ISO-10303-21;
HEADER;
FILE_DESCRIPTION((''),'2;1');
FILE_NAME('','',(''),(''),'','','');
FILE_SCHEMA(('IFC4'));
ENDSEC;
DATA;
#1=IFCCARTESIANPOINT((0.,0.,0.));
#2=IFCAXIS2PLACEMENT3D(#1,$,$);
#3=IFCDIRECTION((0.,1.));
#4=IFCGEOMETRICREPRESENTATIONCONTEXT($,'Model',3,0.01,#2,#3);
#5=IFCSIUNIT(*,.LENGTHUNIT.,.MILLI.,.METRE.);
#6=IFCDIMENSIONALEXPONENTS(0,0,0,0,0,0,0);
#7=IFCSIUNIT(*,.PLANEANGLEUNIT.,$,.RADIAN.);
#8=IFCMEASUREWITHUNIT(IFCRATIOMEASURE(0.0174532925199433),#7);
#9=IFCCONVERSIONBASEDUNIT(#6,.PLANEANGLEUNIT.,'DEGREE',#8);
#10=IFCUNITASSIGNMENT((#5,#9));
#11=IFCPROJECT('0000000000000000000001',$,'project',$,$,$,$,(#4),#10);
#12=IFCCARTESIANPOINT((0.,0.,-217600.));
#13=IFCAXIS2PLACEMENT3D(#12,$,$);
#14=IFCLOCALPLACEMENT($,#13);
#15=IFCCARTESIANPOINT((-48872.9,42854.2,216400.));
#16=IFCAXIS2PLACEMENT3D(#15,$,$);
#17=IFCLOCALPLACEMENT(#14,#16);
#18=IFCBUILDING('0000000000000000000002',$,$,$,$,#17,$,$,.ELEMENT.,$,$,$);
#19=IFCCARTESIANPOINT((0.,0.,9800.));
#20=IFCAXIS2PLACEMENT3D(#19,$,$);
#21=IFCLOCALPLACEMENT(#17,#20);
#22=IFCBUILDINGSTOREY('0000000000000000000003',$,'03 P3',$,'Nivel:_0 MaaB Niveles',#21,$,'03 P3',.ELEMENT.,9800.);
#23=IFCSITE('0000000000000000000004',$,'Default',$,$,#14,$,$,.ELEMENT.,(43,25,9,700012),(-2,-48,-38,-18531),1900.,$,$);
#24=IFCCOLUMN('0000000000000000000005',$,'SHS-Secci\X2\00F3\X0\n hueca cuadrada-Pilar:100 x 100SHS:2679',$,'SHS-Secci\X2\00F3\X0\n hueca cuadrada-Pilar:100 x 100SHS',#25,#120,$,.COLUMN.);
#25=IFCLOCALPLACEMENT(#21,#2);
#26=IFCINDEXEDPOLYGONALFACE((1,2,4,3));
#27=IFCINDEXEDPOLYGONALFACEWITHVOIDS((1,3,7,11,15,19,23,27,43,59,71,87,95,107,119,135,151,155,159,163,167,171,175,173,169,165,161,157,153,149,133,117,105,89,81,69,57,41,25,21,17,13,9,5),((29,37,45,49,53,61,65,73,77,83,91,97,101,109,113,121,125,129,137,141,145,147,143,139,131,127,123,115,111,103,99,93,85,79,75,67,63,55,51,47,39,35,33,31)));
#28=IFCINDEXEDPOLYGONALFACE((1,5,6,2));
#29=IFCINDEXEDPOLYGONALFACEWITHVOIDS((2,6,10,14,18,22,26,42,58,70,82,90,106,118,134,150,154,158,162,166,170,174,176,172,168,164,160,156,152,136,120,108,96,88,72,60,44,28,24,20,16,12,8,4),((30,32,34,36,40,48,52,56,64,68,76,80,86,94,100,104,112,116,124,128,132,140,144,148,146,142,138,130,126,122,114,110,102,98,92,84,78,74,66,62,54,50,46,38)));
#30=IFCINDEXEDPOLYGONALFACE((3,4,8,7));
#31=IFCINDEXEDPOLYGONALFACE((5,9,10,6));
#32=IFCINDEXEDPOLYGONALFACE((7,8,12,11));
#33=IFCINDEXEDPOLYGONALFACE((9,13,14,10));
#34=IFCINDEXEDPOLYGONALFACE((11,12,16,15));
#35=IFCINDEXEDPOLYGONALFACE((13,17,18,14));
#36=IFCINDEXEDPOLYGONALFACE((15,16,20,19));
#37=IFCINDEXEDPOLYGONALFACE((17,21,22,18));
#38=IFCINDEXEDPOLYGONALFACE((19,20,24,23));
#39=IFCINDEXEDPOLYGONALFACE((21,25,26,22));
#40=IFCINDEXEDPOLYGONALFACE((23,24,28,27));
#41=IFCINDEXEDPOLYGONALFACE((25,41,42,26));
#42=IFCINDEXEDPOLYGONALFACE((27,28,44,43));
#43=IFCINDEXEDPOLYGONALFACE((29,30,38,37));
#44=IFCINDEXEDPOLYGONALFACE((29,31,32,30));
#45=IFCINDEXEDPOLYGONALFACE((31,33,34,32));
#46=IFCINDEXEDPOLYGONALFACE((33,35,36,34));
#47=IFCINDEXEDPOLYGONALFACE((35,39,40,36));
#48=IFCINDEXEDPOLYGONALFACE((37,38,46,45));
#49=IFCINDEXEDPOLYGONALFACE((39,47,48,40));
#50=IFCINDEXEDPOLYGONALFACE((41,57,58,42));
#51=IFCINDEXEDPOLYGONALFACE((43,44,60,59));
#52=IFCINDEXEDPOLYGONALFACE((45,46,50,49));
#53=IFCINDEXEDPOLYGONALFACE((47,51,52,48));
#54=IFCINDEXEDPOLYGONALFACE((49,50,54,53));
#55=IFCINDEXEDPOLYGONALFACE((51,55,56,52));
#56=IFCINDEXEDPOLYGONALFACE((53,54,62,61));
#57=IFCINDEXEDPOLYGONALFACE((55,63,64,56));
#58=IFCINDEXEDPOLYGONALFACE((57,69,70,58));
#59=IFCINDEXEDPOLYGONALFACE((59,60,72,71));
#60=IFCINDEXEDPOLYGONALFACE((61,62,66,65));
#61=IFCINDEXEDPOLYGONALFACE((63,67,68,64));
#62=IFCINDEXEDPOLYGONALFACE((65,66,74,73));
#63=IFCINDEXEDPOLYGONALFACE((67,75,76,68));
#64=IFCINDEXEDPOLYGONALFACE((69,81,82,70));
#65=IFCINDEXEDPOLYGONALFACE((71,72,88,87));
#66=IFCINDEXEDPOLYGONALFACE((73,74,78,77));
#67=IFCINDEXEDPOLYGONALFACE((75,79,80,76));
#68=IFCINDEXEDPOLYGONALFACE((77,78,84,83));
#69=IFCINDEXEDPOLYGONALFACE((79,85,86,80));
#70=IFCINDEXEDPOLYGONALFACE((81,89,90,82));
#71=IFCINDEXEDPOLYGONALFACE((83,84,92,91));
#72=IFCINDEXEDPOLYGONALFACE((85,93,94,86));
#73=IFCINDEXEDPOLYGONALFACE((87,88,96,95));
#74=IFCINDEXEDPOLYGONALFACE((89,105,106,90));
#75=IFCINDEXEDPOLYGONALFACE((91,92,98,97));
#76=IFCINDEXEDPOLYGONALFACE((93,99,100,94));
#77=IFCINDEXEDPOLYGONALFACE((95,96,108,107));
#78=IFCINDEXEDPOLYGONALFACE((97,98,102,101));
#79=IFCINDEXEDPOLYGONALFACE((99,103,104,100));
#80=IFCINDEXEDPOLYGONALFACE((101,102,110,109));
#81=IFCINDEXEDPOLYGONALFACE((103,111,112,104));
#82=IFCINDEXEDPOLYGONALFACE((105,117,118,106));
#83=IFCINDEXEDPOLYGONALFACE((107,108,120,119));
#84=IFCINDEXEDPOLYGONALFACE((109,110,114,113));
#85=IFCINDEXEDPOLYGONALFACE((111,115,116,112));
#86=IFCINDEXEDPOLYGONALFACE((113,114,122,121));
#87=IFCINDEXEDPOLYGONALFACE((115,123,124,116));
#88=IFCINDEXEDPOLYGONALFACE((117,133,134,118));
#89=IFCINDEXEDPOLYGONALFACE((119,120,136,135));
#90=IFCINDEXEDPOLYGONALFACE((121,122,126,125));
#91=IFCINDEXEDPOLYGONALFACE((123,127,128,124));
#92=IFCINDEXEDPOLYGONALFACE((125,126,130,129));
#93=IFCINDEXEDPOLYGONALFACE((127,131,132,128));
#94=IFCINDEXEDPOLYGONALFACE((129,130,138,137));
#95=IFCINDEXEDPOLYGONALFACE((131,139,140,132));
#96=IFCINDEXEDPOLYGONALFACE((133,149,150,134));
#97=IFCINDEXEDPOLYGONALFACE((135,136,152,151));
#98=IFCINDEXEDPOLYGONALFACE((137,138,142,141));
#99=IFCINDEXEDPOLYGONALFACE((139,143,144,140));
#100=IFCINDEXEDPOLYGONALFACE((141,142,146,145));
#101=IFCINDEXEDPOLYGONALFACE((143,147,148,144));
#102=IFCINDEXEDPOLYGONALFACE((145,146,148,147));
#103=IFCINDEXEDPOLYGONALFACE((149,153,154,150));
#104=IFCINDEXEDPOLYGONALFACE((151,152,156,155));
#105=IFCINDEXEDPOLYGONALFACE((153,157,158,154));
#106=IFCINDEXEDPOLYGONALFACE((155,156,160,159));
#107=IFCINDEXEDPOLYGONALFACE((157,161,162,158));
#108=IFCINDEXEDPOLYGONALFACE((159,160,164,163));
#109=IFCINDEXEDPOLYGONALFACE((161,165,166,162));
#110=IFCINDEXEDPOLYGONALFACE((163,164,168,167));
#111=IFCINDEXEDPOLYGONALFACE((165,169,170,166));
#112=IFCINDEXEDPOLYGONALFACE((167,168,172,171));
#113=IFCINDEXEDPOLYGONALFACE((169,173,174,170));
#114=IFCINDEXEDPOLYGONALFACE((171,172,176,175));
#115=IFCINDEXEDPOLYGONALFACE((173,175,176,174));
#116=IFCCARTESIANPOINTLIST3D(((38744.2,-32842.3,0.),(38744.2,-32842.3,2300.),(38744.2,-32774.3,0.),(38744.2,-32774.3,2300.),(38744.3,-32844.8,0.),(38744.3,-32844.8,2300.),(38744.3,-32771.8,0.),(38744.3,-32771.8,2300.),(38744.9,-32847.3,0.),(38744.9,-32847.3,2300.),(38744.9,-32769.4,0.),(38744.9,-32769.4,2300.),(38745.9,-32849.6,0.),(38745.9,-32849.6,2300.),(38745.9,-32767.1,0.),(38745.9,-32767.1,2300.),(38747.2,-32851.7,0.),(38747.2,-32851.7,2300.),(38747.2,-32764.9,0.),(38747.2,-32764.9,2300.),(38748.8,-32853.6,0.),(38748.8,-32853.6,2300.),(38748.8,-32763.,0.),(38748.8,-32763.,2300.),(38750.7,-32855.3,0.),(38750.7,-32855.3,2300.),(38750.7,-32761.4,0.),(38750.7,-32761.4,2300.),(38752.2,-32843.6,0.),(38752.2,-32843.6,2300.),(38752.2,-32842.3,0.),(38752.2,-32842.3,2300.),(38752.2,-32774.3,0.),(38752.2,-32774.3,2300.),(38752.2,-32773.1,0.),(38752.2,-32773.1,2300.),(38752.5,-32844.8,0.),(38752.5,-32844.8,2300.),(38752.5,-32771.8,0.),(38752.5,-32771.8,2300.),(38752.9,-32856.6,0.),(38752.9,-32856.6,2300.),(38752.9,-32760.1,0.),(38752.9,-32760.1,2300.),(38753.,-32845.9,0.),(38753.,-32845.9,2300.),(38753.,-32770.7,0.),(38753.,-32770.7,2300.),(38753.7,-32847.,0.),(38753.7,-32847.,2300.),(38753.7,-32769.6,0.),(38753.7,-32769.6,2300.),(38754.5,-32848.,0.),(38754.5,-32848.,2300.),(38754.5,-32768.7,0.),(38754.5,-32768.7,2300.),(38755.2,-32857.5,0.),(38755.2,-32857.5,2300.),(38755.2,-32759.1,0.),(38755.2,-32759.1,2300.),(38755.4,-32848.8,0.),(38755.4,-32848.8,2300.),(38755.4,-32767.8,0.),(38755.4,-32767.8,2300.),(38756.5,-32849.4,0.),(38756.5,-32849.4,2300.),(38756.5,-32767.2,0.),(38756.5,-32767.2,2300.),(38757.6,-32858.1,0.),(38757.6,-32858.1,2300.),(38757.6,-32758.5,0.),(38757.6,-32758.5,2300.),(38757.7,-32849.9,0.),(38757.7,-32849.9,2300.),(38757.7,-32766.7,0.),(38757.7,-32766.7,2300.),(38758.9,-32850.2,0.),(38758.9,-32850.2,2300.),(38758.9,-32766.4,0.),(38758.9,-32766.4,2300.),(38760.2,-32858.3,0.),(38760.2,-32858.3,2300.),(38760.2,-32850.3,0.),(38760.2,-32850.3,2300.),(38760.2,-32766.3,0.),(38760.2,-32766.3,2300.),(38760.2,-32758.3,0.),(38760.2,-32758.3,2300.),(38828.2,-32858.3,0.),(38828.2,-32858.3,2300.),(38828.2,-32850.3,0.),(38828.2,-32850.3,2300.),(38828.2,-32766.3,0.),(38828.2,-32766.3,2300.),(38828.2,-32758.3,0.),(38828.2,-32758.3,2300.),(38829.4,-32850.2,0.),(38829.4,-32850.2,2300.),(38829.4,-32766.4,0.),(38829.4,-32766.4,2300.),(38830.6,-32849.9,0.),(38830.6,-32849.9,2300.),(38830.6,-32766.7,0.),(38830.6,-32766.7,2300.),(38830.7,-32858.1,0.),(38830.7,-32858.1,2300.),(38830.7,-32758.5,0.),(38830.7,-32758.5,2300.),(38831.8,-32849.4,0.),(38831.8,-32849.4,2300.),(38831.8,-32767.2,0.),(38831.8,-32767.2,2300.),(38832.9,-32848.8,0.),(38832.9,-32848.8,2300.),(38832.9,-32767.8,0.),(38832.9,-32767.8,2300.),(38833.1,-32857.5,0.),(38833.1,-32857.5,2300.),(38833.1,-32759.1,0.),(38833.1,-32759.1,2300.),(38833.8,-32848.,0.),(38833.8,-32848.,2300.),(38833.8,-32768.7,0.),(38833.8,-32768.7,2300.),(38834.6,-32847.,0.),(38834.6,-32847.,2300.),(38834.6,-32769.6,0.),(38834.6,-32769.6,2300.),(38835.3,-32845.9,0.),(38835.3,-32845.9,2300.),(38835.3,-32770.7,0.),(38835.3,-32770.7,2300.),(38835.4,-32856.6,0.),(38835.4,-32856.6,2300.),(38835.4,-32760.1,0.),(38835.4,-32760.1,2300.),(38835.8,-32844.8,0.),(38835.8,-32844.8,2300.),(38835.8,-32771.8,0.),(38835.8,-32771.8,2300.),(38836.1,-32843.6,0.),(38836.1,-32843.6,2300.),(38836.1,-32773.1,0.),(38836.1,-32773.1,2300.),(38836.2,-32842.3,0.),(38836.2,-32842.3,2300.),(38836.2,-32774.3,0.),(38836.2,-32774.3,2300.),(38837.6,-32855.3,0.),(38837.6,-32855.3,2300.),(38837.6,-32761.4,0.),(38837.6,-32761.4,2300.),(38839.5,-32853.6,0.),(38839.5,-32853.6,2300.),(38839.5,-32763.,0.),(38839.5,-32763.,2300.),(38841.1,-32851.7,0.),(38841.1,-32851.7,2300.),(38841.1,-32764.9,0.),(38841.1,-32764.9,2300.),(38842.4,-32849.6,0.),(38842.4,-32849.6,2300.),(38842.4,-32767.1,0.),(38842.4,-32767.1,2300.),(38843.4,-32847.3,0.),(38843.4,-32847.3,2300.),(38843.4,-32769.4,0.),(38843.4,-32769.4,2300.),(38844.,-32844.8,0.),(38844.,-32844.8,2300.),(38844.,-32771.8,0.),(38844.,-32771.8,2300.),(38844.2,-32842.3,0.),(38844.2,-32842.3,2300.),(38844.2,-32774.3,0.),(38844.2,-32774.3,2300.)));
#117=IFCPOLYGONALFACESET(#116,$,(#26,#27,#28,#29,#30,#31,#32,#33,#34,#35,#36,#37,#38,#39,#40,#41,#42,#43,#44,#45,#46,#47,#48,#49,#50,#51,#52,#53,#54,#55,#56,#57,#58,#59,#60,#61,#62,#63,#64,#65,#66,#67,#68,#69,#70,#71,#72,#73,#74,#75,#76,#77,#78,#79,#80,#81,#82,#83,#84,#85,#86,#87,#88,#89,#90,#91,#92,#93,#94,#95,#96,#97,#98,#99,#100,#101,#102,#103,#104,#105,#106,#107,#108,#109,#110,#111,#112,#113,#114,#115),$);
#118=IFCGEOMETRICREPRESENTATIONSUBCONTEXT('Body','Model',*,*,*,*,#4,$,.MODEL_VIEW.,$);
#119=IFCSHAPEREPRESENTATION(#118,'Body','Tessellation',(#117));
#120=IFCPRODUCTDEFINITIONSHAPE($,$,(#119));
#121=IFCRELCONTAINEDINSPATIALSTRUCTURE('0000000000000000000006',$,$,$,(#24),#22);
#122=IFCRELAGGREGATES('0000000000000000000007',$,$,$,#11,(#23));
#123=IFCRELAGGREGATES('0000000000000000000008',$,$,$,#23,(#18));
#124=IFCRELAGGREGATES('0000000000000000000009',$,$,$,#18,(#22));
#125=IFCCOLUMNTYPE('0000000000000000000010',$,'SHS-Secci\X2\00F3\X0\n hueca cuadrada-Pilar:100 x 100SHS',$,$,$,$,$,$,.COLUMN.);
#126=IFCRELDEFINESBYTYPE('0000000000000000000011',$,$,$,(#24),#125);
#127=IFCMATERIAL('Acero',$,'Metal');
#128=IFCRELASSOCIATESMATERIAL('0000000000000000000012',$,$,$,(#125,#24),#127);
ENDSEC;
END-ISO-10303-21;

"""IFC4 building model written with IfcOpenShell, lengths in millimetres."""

from ifc_helpers import new_model, entity, si_unit, converted_unit, direction, frame, origin, place, context, subcontext, project, spatial, indexed_curve, outline, extrude, source, transform, mapped, material, type_object, type_shapes, element, save


model = new_model("IFC4")

# Units and contexts
model_context = context("Model", 3, precision=0.01, world=origin(), true_north=direction((0.0, 1.0)))
body_context = subcontext(model_context, "Body", "Model", "MODEL_VIEW")
ifc_project = project(units=[si_unit("LENGTHUNIT", "METRE", prefix="MILLI"), converted_unit("PLANEANGLEUNIT", "DEGREE", entity("IfcRatioMeasure", 0.0174532925199433), si_unit("PLANEANGLEUNIT", "RADIAN"), dimensions=[0, 0, 0, 0, 0, 0, 0])], contexts=[model_context])

# Site, building, storey
site_placement = place(None, frame((0.0, 0.0, -217600.0)))
site = spatial("IfcSite", under=ifc_project, at=site_placement, Name="Default", CompositionType="ELEMENT", RefLatitude=(43, 25, 9, 700012), RefLongitude=(-2, -48, -38, -18531), RefElevation=1900.0)
building_placement = place(site_placement, frame((-48872.9, 42854.2, 216400.0)))
building = spatial("IfcBuilding", under=site, at=building_placement, CompositionType="ELEMENT")
storey_placement = place(building_placement, frame((0.0, 0.0, 9800.0)))
storey = spatial("IfcBuildingStorey", under=building, at=storey_placement, Name="03 P3", ObjectType="Nivel:_0 MaaB Niveles", LongName="03 P3", CompositionType="ELEMENT", Elevation=9800.0)

# Column
ifc_material_1 = material(Name="Acero", Category="Metal")
column_type_1 = type_object("IfcColumnType", Name="SHS-Sección hueca cuadrada-Pilar:100 x 100SHS", PredefinedType="COLUMN", material=ifc_material_1)
shared_shape_1 = source(origin(), body_context, "Body", "SweptSolid", [
    extrude(outline(indexed_curve([(-34.0, -50.0), (34.0, -50.0), (36.5, -49.8), (38.9, -49.2), (41.3, -48.3), (43.4, -46.9), (45.3, -45.3), (46.9, -43.4), (48.3, -41.3), (49.2, -38.9), (49.8, -36.5), (50.0, -34.0), (50.0, 34.0), (49.8, 36.5), (49.2, 38.9), (48.3, 41.3), (46.9, 43.4), (45.3, 45.3), (43.4, 46.9), (41.3, 48.3), (38.9, 49.2), (36.5, 49.8), (34.0, 50.0), (-34.0, 50.0), (-36.5, 49.8), (-38.9, 49.2), (-41.3, 48.3), (-43.4, 46.9), (-45.3, 45.3), (-46.9, 43.4), (-48.3, 41.3), (-49.2, 38.9), (-49.8, 36.5), (-50.0, 34.0), (-50.0, -34.0), (-49.8, -36.5), (-49.2, -38.9), (-48.3, -41.3), (-46.9, -43.4), (-45.3, -45.3), (-43.4, -46.9), (-41.3, -48.3), (-38.9, -49.2), (-36.5, -49.8), (-34.0, -50.0)], self_intersect=False), holes=[indexed_curve([(-42.0, 34.0), (-41.9, 35.3), (-41.6, 36.5), (-41.1, 37.6), (-40.5, 38.7), (-39.7, 39.7), (-38.7, 40.5), (-37.6, 41.1), (-36.5, 41.6), (-35.3, 41.9), (-34.0, 42.0), (34.0, 42.0), (35.3, 41.9), (36.5, 41.6), (37.6, 41.1), (38.7, 40.5), (39.7, 39.7), (40.5, 38.7), (41.1, 37.6), (41.6, 36.5), (41.9, 35.3), (42.0, 34.0), (42.0, -34.0), (41.9, -35.3), (41.6, -36.5), (41.1, -37.6), (40.5, -38.7), (39.7, -39.7), (38.7, -40.5), (37.6, -41.1), (36.5, -41.6), (35.3, -41.9), (34.0, -42.0), (-34.0, -42.0), (-35.3, -41.9), (-36.5, -41.6), (-37.6, -41.1), (-38.7, -40.5), (-39.7, -39.7), (-40.5, -38.7), (-41.1, -37.6), (-41.6, -36.5), (-41.9, -35.3), (-42.0, -34.0), (-42.0, 34.0)], self_intersect=False)]), frame((0.0, 0.0, 9800.0), z_axis=(0.0, 0.0, 1.0), x_axis=(0.0, 1.0, 0.0)), (0.0, 0.0, 1.0), 2300.0),
])
type_shapes(column_type_1, [shared_shape_1])
column_1_placement = place(storey_placement, frame((38794.2, -32808.3, -9800.0), z_axis=(0.0, 0.0, 1.0), x_axis=(0.0, -1.0, 0.0)))
element("IfcColumn", 1, at=column_1_placement, inside=storey, type_object=column_type_1, material=ifc_material_1, Name="SHS-Sección hueca cuadrada-Pilar:100 x 100SHS:2679", ObjectType="SHS-Sección hueca cuadrada-Pilar:100 x 100SHS", PredefinedType="COLUMN", context=body_context, shape_type="MappedRepresentation", body=[
    mapped(shared_shape_1, transform((0.0, 0.0, 0.0), scale=1.0)),
])

save(model, "model.ifc")
